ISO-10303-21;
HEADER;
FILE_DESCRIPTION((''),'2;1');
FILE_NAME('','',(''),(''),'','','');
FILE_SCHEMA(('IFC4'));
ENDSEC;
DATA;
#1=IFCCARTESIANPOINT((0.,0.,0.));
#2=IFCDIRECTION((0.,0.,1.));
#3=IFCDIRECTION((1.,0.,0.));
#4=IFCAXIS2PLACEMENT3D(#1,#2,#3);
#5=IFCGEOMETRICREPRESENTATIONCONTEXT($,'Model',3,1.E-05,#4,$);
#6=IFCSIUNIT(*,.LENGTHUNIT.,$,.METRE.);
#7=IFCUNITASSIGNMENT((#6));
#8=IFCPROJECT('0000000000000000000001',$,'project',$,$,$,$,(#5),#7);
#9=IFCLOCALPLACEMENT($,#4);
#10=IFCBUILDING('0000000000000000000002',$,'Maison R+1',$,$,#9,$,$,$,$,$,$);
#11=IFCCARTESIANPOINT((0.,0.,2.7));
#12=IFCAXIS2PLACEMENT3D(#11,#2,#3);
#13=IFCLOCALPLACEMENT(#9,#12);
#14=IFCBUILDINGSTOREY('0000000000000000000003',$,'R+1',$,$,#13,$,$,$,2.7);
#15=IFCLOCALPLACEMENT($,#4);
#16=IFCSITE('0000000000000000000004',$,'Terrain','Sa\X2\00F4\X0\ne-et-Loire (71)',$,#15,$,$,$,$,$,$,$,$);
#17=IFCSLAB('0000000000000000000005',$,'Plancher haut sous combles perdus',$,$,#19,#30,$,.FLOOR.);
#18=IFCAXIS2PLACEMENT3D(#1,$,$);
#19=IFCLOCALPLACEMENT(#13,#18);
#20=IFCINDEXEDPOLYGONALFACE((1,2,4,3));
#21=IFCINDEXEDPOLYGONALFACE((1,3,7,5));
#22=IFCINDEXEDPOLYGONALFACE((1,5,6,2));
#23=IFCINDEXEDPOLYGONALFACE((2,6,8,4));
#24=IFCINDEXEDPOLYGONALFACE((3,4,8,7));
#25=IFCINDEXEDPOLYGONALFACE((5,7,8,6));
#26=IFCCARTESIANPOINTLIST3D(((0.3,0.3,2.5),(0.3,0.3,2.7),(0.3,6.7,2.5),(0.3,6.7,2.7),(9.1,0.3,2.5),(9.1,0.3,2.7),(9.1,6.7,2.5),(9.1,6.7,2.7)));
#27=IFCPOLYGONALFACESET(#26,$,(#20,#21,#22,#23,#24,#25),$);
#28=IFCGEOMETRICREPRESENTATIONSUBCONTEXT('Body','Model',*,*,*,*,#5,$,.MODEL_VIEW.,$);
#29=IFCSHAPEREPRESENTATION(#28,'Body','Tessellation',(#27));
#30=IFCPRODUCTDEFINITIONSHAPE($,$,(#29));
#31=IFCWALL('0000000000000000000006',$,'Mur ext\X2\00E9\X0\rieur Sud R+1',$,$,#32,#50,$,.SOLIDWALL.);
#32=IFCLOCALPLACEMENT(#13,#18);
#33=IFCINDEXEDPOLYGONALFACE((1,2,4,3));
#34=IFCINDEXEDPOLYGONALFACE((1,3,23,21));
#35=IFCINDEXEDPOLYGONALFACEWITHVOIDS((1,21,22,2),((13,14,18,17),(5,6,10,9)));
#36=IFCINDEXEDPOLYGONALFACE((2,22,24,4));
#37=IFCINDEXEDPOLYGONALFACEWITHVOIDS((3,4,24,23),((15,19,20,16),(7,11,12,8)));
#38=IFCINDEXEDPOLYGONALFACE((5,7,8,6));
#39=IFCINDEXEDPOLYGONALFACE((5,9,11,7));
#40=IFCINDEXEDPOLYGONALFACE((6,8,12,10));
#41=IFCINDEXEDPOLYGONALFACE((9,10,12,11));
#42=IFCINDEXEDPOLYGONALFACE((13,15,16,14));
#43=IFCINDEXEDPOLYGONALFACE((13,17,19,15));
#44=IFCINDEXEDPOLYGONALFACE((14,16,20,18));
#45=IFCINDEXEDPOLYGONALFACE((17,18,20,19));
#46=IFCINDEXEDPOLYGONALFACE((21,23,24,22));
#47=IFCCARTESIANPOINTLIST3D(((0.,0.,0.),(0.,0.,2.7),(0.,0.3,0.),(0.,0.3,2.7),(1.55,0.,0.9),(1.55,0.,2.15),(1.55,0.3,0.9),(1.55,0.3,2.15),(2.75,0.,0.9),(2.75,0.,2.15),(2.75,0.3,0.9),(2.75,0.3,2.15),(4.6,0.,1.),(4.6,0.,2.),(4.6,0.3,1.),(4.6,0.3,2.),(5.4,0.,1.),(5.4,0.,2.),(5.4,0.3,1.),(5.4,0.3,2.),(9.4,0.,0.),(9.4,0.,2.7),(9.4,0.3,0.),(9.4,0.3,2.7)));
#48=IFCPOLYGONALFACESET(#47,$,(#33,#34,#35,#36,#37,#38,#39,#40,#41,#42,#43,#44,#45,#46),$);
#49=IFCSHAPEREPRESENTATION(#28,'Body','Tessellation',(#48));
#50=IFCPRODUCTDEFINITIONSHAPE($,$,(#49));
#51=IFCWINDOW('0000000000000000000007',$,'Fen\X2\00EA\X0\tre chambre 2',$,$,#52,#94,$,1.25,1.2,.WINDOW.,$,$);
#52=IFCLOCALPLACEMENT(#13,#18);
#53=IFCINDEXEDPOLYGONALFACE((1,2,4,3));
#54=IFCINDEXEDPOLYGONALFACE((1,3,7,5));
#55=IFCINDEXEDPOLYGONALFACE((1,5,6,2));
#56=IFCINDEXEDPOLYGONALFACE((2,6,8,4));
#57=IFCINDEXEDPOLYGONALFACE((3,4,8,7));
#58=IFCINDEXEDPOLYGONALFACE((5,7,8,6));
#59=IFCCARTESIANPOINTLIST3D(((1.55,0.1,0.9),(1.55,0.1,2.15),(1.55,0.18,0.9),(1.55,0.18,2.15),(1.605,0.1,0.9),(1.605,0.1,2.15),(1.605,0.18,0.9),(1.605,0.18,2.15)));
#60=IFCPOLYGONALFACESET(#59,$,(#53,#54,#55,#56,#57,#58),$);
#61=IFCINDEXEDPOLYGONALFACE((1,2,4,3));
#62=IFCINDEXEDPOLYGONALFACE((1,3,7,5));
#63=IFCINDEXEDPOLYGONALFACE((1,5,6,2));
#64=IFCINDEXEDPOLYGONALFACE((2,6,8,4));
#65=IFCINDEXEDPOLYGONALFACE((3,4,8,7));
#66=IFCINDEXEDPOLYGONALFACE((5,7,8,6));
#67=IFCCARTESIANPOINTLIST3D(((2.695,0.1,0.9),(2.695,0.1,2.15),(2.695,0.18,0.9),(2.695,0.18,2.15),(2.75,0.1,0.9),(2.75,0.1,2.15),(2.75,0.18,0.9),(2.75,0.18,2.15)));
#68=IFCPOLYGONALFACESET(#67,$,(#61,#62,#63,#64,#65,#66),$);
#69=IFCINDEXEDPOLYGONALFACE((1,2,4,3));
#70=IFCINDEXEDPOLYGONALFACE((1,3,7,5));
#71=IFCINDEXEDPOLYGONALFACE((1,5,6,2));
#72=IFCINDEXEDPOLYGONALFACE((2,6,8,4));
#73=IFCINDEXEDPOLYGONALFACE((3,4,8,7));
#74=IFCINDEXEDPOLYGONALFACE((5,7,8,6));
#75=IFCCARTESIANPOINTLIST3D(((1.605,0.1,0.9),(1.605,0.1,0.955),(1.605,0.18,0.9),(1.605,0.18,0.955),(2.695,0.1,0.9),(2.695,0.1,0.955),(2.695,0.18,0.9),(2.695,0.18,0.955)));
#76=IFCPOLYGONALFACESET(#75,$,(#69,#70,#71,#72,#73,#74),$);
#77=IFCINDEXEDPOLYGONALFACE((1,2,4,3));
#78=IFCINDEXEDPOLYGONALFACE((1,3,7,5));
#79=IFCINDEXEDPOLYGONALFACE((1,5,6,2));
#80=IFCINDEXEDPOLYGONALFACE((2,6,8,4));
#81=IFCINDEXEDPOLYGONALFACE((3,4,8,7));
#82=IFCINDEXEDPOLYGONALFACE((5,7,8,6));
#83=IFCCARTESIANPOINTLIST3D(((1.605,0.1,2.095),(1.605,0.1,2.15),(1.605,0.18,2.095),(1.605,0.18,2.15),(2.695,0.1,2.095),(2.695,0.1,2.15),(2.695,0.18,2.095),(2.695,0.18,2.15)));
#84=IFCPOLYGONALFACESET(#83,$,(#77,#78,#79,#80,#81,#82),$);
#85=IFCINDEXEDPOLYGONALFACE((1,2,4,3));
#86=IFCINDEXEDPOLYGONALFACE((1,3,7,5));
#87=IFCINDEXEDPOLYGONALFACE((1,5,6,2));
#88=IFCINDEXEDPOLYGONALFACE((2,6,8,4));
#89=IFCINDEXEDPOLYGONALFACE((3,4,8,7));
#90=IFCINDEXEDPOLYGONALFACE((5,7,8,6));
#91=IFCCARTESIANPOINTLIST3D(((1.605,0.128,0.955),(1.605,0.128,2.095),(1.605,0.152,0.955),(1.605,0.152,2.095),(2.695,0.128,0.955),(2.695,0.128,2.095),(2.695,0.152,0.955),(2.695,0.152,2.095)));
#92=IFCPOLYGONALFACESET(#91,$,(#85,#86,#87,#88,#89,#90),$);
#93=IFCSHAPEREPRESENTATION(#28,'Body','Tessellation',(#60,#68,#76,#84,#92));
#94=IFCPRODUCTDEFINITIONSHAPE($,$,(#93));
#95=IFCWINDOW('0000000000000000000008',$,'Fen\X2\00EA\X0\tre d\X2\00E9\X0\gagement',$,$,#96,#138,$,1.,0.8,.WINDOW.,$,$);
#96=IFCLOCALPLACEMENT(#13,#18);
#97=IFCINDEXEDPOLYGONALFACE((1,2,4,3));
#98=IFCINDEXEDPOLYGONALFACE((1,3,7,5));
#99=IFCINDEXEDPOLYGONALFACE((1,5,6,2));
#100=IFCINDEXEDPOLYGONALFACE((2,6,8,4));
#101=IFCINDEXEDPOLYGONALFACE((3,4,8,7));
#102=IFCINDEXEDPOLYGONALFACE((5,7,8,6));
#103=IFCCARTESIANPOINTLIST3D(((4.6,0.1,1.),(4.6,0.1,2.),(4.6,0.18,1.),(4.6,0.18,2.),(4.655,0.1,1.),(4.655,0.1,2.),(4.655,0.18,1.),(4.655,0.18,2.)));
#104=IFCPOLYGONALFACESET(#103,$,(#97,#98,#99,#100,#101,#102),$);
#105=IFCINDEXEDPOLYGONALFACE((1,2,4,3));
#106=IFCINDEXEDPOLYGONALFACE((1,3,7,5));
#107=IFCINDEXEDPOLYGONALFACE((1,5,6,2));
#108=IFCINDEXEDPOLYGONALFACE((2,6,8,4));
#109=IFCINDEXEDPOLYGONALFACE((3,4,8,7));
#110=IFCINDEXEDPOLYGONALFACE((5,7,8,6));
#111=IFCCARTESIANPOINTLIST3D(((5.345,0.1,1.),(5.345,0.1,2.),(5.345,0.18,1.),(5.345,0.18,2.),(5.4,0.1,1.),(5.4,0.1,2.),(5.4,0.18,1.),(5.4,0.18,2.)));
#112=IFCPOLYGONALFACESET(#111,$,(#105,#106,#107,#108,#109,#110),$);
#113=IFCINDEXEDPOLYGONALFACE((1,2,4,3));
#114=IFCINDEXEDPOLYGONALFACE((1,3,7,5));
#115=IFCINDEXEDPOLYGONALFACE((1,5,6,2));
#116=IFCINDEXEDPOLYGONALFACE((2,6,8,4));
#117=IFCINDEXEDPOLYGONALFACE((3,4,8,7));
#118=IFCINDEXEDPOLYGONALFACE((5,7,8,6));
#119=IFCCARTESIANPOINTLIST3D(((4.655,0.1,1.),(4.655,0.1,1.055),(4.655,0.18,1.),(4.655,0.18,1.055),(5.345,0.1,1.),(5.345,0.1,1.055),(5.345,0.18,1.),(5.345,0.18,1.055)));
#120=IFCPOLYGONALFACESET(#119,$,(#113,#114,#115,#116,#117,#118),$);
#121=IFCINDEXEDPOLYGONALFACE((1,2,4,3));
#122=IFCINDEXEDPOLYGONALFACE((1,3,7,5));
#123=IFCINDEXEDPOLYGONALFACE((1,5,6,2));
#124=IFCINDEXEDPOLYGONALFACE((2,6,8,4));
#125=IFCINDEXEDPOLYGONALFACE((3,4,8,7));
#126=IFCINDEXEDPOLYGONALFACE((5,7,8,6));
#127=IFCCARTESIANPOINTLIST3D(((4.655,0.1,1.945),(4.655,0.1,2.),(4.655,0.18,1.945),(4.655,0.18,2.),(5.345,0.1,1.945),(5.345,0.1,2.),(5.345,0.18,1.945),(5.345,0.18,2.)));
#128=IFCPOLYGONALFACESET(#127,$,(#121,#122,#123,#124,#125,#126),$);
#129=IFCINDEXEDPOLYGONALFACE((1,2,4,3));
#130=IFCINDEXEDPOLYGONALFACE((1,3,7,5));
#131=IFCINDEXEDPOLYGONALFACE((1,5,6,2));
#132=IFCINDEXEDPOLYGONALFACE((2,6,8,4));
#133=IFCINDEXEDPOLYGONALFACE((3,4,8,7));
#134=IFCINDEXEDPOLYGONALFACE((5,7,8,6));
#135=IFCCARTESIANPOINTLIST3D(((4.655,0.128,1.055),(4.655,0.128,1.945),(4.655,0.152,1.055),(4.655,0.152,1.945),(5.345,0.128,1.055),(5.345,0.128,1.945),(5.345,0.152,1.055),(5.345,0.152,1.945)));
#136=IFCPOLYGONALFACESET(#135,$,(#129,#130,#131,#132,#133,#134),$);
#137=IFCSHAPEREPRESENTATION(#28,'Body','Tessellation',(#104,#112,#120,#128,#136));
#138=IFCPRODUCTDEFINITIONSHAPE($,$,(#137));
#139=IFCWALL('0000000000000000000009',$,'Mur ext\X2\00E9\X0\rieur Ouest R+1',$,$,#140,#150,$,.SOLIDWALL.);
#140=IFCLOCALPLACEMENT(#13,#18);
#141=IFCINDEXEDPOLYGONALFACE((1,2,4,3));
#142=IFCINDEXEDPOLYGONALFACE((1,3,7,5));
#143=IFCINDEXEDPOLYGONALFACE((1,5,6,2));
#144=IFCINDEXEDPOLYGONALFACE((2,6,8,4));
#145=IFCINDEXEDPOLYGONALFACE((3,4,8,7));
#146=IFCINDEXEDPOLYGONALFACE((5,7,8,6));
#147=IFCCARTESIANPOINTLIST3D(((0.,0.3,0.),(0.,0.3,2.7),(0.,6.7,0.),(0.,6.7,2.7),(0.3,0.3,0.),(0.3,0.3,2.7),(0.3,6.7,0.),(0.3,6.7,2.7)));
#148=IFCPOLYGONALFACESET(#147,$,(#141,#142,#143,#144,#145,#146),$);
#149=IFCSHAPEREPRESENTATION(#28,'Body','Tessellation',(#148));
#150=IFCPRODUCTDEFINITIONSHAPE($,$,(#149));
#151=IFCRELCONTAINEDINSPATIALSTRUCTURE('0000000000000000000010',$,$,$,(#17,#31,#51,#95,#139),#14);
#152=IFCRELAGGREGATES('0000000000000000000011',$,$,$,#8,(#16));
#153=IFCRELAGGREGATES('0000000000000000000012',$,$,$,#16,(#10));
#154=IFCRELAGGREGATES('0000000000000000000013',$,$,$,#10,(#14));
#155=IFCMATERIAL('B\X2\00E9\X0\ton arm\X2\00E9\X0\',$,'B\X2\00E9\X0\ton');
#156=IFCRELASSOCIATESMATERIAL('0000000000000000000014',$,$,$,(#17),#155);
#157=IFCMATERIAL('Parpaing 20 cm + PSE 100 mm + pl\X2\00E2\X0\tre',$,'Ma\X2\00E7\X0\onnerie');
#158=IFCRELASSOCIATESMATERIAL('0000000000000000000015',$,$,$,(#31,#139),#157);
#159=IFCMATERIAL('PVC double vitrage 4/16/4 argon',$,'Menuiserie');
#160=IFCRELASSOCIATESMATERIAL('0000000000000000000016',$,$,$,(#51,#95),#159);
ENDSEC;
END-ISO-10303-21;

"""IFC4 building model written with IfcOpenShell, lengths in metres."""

from ifc_helpers import new_model, si_unit, frame, frame_2d, origin_with_axes, place, context, subcontext, project, spatial, rectangle, extrude, material, element, fill, save


model = new_model("IFC4")

# Units and contexts
model_context = context("Model", 3, precision=1e-05, world=origin_with_axes())
body_context = subcontext(model_context, "Body", "Model", "MODEL_VIEW")
ifc_project = project(units=[si_unit("LENGTHUNIT", "METRE")], contexts=[model_context])

# Site, building, storey
site_placement = place(None, origin_with_axes())
site = spatial("IfcSite", under=ifc_project, at=site_placement, Name="Terrain", Description="Saône-et-Loire (71)")
building_placement = place(None, origin_with_axes())
building = spatial("IfcBuilding", under=site, at=building_placement, Name="Maison R+1")
storey_placement = place(building_placement, frame((0.0, 0.0, 2.7), z_axis=(0.0, 0.0, 1.0), x_axis=(1.0, 0.0, 0.0)))
storey = spatial("IfcBuildingStorey", under=building, at=storey_placement, Name="R+1", Elevation=2.7)

# Slab
ifc_material_1 = material(Name="Béton armé", Category="Béton")
slab_placement = place(storey_placement, frame((0.3, 0.3, 2.5), z_axis=(0.0, 0.0, 1.0), x_axis=(1.0, 0.0, 0.0)))
element("IfcSlab", 1, at=slab_placement, inside=storey, material=ifc_material_1, Name="Plancher haut sous combles perdus", PredefinedType="FLOOR", context=body_context, shape_type="SweptSolid", body=[
    extrude(rectangle(XDim=8.8, YDim=6.4, at=frame_2d((4.4, 3.2))), origin_with_axes(), (0.0, 0.0, 1.0), 0.2),
])

# Wall, openings, windows
ifc_material_2 = material(Name="Parpaing 20 cm + PSE 100 mm + plâtre", Category="Maçonnerie")
wall_1_placement = place(storey_placement, origin_with_axes())
wall_1 = element("IfcWall", 2, at=wall_1_placement, inside=storey, material=ifc_material_2, Name="Mur extérieur Sud R+1", PredefinedType="SOLIDWALL", context=body_context, shape_type="SweptSolid", body=[
    extrude(rectangle(XDim=9.4, YDim=0.3, at=frame_2d((4.7, 0.15))), origin_with_axes(), (0.0, 0.0, 1.0), 2.7),
])
opening_1_placement = place(storey_placement, frame((1.55, -0.05, 0.9), z_axis=(0.0, 0.0, 1.0), x_axis=(1.0, 0.0, 0.0)))
opening_1 = element("IfcOpeningElement", 3, at=opening_1_placement, cuts=wall_1, context=body_context, shape_type="SweptSolid", body=[
    extrude(rectangle(XDim=1.2, YDim=0.4, at=frame_2d((0.6, 0.2))), origin_with_axes(), (0.0, 0.0, 1.0), 1.25),
])
opening_2_placement = place(storey_placement, frame((4.6, -0.05, 1.0), z_axis=(0.0, 0.0, 1.0), x_axis=(1.0, 0.0, 0.0)))
opening_2 = element("IfcOpeningElement", 4, at=opening_2_placement, cuts=wall_1, context=body_context, shape_type="SweptSolid", body=[
    extrude(rectangle(XDim=0.8, YDim=0.4, at=frame_2d((0.4, 0.2))), origin_with_axes(), (0.0, 0.0, 1.0), 1.0),
])
ifc_material_3 = material(Name="PVC double vitrage 4/16/4 argon", Category="Menuiserie")
window_1_placement = place(storey_placement, frame((1.55, 0.1, 0.9), z_axis=(0.0, 0.0, 1.0), x_axis=(1.0, 0.0, 0.0)))
window_1 = element("IfcWindow", 5, at=window_1_placement, inside=storey, material=ifc_material_3, Name="Fenêtre chambre 2", OverallHeight=1.25, OverallWidth=1.2, PredefinedType="WINDOW", context=body_context, shape_type="SweptSolid", body=[
    extrude(rectangle(XDim=0.055, YDim=0.08, at=frame_2d((0.0275, 0.04))), origin_with_axes(), (0.0, 0.0, 1.0), 1.25),
    extrude(rectangle(XDim=0.055, YDim=0.08, at=frame_2d((0.0275, 0.04))), frame((1.145, 0.0, 0.0), z_axis=(0.0, 0.0, 1.0), x_axis=(1.0, 0.0, 0.0)), (0.0, 0.0, 1.0), 1.25),
    extrude(rectangle(XDim=1.09, YDim=0.08, at=frame_2d((0.545, 0.04))), frame((0.055, 0.0, 0.0), z_axis=(0.0, 0.0, 1.0), x_axis=(1.0, 0.0, 0.0)), (0.0, 0.0, 1.0), 0.055),
    extrude(rectangle(XDim=1.09, YDim=0.08, at=frame_2d((0.545, 0.04))), frame((0.055, 0.0, 1.195), z_axis=(0.0, 0.0, 1.0), x_axis=(1.0, 0.0, 0.0)), (0.0, 0.0, 1.0), 0.055),
    extrude(rectangle(XDim=1.09, YDim=0.024, at=frame_2d((0.545, 0.012))), frame((0.055, 0.028, 0.055), z_axis=(0.0, 0.0, 1.0), x_axis=(1.0, 0.0, 0.0)), (0.0, 0.0, 1.0), 1.14),
])
fill(opening_1, window_1)
window_2_placement = place(storey_placement, frame((4.6, 0.1, 1.0), z_axis=(0.0, 0.0, 1.0), x_axis=(1.0, 0.0, 0.0)))
window_2 = element("IfcWindow", 6, at=window_2_placement, inside=storey, material=ifc_material_3, Name="Fenêtre dégagement", OverallHeight=1.0, OverallWidth=0.8, PredefinedType="WINDOW", context=body_context, shape_type="SweptSolid", body=[
    extrude(rectangle(XDim=0.055, YDim=0.08, at=frame_2d((0.0275, 0.04))), origin_with_axes(), (0.0, 0.0, 1.0), 1.0),
    extrude(rectangle(XDim=0.055, YDim=0.08, at=frame_2d((0.0275, 0.04))), frame((0.745, 0.0, 0.0), z_axis=(0.0, 0.0, 1.0), x_axis=(1.0, 0.0, 0.0)), (0.0, 0.0, 1.0), 1.0),
    extrude(rectangle(XDim=0.69, YDim=0.08, at=frame_2d((0.345, 0.04))), frame((0.055, 0.0, 0.0), z_axis=(0.0, 0.0, 1.0), x_axis=(1.0, 0.0, 0.0)), (0.0, 0.0, 1.0), 0.055),
    extrude(rectangle(XDim=0.69, YDim=0.08, at=frame_2d((0.345, 0.04))), frame((0.055, 0.0, 0.945), z_axis=(0.0, 0.0, 1.0), x_axis=(1.0, 0.0, 0.0)), (0.0, 0.0, 1.0), 0.055),
    extrude(rectangle(XDim=0.69, YDim=0.024, at=frame_2d((0.345, 0.012))), frame((0.055, 0.028, 0.055), z_axis=(0.0, 0.0, 1.0), x_axis=(1.0, 0.0, 0.0)), (0.0, 0.0, 1.0), 0.89),
])
fill(opening_2, window_2)

# Wall
wall_2_placement = place(storey_placement, frame((0.0, 0.3, 0.0), z_axis=(0.0, 0.0, 1.0), x_axis=(1.0, 0.0, 0.0)))
element("IfcWall", 7, at=wall_2_placement, inside=storey, material=ifc_material_2, Name="Mur extérieur Ouest R+1", PredefinedType="SOLIDWALL", context=body_context, shape_type="SweptSolid", body=[
    extrude(rectangle(XDim=0.3, YDim=6.4, at=frame_2d((0.15, 3.2))), origin_with_axes(), (0.0, 0.0, 1.0), 2.7),
])

save(model, "model.ifc")
